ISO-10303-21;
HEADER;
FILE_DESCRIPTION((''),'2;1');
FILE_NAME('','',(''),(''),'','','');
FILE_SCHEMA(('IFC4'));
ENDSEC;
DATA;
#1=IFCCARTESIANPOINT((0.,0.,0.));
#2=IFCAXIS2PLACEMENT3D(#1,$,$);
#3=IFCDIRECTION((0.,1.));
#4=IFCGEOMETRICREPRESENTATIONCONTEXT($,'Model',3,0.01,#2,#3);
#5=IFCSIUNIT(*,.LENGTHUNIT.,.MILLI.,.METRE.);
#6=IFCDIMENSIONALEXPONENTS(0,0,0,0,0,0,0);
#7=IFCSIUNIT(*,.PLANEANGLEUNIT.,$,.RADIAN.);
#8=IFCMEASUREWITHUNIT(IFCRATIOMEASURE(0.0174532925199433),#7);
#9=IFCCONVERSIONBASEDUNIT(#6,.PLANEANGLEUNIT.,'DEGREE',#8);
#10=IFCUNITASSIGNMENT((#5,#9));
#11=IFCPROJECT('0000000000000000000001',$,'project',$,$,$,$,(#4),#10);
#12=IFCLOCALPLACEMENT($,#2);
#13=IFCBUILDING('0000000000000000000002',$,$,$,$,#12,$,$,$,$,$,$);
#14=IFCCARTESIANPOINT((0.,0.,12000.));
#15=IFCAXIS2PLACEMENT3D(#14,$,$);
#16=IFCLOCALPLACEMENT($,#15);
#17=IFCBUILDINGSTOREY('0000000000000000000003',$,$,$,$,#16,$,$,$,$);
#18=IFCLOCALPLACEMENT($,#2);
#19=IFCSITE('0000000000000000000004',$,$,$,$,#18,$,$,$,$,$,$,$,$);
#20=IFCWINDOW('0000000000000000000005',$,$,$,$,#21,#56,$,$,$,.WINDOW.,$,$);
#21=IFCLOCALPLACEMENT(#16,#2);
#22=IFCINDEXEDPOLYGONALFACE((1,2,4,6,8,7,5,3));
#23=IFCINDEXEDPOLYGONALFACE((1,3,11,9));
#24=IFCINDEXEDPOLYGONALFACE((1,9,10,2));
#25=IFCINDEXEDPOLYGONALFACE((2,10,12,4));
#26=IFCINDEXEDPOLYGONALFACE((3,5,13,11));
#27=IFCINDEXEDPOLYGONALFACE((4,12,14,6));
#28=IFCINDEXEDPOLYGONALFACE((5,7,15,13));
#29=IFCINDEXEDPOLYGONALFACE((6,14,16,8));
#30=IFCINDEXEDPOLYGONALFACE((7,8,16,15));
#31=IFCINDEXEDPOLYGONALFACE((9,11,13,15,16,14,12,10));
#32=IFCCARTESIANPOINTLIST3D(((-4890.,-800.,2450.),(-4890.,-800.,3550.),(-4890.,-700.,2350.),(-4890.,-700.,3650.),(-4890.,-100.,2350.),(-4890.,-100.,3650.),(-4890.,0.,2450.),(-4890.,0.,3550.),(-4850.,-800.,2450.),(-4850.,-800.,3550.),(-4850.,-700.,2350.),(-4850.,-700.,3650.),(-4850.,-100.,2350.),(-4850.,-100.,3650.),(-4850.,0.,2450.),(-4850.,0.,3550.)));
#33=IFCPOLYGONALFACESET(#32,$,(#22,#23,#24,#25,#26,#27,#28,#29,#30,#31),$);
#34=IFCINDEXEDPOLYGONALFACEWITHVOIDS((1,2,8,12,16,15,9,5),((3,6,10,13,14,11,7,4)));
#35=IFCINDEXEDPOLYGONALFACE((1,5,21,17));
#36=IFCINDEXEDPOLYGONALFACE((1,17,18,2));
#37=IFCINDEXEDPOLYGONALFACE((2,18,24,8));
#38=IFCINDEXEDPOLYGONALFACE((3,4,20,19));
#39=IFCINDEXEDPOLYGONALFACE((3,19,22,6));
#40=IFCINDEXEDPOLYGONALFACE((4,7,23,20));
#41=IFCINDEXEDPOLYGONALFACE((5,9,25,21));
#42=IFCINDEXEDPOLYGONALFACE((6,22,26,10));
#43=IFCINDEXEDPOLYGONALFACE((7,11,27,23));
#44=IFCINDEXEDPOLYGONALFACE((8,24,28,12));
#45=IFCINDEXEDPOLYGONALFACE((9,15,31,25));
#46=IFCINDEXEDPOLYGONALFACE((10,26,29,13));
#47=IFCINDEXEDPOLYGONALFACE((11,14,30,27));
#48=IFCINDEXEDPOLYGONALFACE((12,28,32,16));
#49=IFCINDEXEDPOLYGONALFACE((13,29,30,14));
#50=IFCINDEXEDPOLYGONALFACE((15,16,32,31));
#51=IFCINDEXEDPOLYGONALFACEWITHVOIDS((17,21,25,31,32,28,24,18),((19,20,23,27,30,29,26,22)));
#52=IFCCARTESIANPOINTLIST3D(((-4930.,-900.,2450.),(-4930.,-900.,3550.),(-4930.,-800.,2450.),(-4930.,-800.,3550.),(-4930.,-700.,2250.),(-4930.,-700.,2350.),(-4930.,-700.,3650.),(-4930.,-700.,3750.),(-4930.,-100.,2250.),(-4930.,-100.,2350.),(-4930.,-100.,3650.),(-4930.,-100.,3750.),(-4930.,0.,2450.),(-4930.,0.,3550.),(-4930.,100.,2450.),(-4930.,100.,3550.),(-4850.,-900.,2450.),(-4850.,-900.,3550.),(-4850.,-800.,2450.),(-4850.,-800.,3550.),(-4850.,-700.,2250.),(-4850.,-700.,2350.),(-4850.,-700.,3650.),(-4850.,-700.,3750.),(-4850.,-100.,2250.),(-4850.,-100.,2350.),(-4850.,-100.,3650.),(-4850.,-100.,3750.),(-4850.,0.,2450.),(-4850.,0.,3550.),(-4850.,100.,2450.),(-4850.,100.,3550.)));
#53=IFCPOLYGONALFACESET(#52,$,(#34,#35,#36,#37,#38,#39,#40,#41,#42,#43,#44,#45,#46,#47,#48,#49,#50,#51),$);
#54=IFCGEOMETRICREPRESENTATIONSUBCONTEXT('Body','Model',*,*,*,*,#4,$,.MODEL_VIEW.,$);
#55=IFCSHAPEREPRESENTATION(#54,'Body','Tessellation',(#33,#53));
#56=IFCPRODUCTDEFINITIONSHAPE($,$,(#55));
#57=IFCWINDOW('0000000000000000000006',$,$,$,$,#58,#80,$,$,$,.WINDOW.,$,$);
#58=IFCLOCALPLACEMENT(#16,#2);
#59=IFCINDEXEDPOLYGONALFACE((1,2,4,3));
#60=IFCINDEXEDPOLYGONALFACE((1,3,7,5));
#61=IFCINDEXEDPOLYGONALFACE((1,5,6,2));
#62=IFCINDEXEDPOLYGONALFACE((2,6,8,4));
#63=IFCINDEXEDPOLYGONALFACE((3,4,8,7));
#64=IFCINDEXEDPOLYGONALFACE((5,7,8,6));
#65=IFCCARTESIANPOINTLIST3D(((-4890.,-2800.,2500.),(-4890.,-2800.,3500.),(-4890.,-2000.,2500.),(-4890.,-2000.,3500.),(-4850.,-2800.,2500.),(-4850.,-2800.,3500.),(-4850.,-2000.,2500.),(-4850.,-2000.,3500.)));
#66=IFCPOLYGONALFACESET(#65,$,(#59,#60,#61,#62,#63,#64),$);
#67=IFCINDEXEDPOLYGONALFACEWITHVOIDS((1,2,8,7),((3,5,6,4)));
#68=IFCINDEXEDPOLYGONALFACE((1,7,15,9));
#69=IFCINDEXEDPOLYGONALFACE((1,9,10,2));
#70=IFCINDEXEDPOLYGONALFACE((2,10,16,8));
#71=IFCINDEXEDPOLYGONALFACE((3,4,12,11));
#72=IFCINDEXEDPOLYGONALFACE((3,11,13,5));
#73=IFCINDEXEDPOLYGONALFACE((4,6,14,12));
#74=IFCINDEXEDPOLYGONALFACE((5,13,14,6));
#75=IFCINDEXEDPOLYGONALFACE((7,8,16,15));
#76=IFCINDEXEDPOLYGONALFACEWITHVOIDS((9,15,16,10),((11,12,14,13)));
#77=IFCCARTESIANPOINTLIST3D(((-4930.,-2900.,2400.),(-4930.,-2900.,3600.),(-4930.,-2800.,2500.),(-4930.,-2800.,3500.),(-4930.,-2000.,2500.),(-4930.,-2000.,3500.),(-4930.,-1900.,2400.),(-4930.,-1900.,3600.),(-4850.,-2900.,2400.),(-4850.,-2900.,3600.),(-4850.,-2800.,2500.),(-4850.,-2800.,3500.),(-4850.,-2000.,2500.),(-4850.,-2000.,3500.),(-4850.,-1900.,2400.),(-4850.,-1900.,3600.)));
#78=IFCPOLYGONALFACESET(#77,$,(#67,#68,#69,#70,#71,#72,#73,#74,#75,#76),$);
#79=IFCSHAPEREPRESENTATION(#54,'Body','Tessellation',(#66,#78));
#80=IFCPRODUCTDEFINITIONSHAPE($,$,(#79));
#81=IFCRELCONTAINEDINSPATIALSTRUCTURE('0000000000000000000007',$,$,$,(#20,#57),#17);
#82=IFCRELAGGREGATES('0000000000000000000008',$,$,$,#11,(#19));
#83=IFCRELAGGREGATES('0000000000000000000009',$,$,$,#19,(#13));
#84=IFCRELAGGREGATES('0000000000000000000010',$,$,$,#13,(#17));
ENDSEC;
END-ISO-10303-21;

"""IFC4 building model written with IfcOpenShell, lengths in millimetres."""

from ifc_helpers import new_model, entity, si_unit, converted_unit, direction, frame, origin, place, context, subcontext, project, spatial, element, save


model = new_model("IFC4")

# Units and contexts
model_context = context("Model", 3, precision=0.01, world=origin(), true_north=direction((0.0, 1.0)))
body_context = subcontext(model_context, "Body", "Model", "MODEL_VIEW")
ifc_project = project(units=[si_unit("LENGTHUNIT", "METRE", prefix="MILLI"), converted_unit("PLANEANGLEUNIT", "DEGREE", entity("IfcRatioMeasure", 0.0174532925199433), si_unit("PLANEANGLEUNIT", "RADIAN"), dimensions=[0, 0, 0, 0, 0, 0, 0])], contexts=[model_context])

# Site, building, storey
site_placement = place(None, origin())
site = spatial("IfcSite", under=ifc_project, at=site_placement)
building_placement = place(None, origin())
building = spatial("IfcBuilding", under=site, at=building_placement)
storey_placement = place(None, frame((0.0, 0.0, 12000.0)))
storey = spatial("IfcBuildingStorey", under=building, at=storey_placement)

# Shared definitions
cartesian_point_1 = entity("IfcCartesianPoint", [-400.0, -550.0])
shared_polyline_1 = entity("IfcPolyline", [cartesian_point_1, entity("IfcCartesianPoint", [-400.0, 550.0]), entity("IfcCartesianPoint", [-300.0, 650.0]), entity("IfcCartesianPoint", [300.0, 650.0]), entity("IfcCartesianPoint", [400.0, 550.0]), entity("IfcCartesianPoint", [400.0, -550.0]), entity("IfcCartesianPoint", [300.0, -650.0]), entity("IfcCartesianPoint", [-300.0, -650.0]), cartesian_point_1])
cartesian_point_2 = entity("IfcCartesianPoint", [-400.0, -500.0])
shared_polyline_2 = entity("IfcPolyline", [cartesian_point_2, entity("IfcCartesianPoint", [-400.0, 500.0]), entity("IfcCartesianPoint", [-400.0, 500.0]), entity("IfcCartesianPoint", [400.0, 500.0]), entity("IfcCartesianPoint", [400.0, 500.0]), entity("IfcCartesianPoint", [400.0, -500.0]), entity("IfcCartesianPoint", [400.0, -500.0]), entity("IfcCartesianPoint", [-400.0, -500.0]), cartesian_point_2])

# Shared definitions
wall_1_placement = place(storey_placement, frame((-4900.0, 100.0, 0.0), z_axis=(0.0, 0.0, 1.0), x_axis=(0.0, -1.0, 0.0)))
window_1_placement = place(wall_1_placement, frame((500.0, 50.0, 3000.0)))
window_2_placement = place(wall_1_placement, frame((2500.0, 50.0, 3000.0)))

# Windows
cartesian_point_3 = entity("IfcCartesianPoint", [-500.0, -550.0])
element("IfcWindow", 1, at=window_1_placement, inside=storey, PredefinedType="WINDOW", context=body_context, shape_type="SweptSolid", body=[
    entity("IfcExtrudedAreaSolid", entity("IfcArbitraryClosedProfileDef", "AREA", None, shared_polyline_1), entity("IfcAxis2Placement3D", entity("IfcCartesianPoint", [0.0, 0.0, 0.0]), entity("IfcDirection", [0.0, -1.0, 0.0]), entity("IfcDirection", [1.0, 0.0, 0.0])), entity("IfcDirection", [0.0, 0.0, 1.0]), 40.0),
    entity("IfcExtrudedAreaSolid", entity("IfcArbitraryProfileDefWithVoids", "AREA", None, entity("IfcPolyline", [cartesian_point_3, entity("IfcCartesianPoint", [-500.0, 550.0]), entity("IfcCartesianPoint", [-300.0, 750.0]), entity("IfcCartesianPoint", [300.0, 750.0]), entity("IfcCartesianPoint", [500.0, 550.0]), entity("IfcCartesianPoint", [500.0, -550.0]), entity("IfcCartesianPoint", [300.0, -750.0]), entity("IfcCartesianPoint", [-300.0, -750.0]), cartesian_point_3]), [shared_polyline_1]), entity("IfcAxis2Placement3D", entity("IfcCartesianPoint", [0.0, 0.0, 0.0]), entity("IfcDirection", [0.0, -1.0, 0.0]), entity("IfcDirection", [1.0, 0.0, 0.0])), entity("IfcDirection", [0.0, 0.0, 1.0]), 80.0),
])
cartesian_point_4 = entity("IfcCartesianPoint", [-500.0, -600.0])
element("IfcWindow", 2, at=window_2_placement, inside=storey, PredefinedType="WINDOW", context=body_context, shape_type="SweptSolid", body=[
    entity("IfcExtrudedAreaSolid", entity("IfcArbitraryClosedProfileDef", "AREA", None, shared_polyline_2), entity("IfcAxis2Placement3D", entity("IfcCartesianPoint", [0.0, 0.0, 0.0]), entity("IfcDirection", [0.0, -1.0, 0.0]), entity("IfcDirection", [1.0, 0.0, 0.0])), entity("IfcDirection", [0.0, 0.0, 1.0]), 40.0),
    entity("IfcExtrudedAreaSolid", entity("IfcArbitraryProfileDefWithVoids", "AREA", None, entity("IfcPolyline", [cartesian_point_4, entity("IfcCartesianPoint", [-500.0, 600.0]), entity("IfcCartesianPoint", [-500.0, 600.0]), entity("IfcCartesianPoint", [500.0, 600.0]), entity("IfcCartesianPoint", [500.0, 600.0]), entity("IfcCartesianPoint", [500.0, -600.0]), entity("IfcCartesianPoint", [500.0, -600.0]), entity("IfcCartesianPoint", [-500.0, -600.0]), cartesian_point_4]), [shared_polyline_2]), entity("IfcAxis2Placement3D", entity("IfcCartesianPoint", [0.0, 0.0, 0.0]), entity("IfcDirection", [0.0, -1.0, 0.0]), entity("IfcDirection", [1.0, 0.0, 0.0])), entity("IfcDirection", [0.0, 0.0, 1.0]), 80.0),
])

save(model, "model.ifc")
